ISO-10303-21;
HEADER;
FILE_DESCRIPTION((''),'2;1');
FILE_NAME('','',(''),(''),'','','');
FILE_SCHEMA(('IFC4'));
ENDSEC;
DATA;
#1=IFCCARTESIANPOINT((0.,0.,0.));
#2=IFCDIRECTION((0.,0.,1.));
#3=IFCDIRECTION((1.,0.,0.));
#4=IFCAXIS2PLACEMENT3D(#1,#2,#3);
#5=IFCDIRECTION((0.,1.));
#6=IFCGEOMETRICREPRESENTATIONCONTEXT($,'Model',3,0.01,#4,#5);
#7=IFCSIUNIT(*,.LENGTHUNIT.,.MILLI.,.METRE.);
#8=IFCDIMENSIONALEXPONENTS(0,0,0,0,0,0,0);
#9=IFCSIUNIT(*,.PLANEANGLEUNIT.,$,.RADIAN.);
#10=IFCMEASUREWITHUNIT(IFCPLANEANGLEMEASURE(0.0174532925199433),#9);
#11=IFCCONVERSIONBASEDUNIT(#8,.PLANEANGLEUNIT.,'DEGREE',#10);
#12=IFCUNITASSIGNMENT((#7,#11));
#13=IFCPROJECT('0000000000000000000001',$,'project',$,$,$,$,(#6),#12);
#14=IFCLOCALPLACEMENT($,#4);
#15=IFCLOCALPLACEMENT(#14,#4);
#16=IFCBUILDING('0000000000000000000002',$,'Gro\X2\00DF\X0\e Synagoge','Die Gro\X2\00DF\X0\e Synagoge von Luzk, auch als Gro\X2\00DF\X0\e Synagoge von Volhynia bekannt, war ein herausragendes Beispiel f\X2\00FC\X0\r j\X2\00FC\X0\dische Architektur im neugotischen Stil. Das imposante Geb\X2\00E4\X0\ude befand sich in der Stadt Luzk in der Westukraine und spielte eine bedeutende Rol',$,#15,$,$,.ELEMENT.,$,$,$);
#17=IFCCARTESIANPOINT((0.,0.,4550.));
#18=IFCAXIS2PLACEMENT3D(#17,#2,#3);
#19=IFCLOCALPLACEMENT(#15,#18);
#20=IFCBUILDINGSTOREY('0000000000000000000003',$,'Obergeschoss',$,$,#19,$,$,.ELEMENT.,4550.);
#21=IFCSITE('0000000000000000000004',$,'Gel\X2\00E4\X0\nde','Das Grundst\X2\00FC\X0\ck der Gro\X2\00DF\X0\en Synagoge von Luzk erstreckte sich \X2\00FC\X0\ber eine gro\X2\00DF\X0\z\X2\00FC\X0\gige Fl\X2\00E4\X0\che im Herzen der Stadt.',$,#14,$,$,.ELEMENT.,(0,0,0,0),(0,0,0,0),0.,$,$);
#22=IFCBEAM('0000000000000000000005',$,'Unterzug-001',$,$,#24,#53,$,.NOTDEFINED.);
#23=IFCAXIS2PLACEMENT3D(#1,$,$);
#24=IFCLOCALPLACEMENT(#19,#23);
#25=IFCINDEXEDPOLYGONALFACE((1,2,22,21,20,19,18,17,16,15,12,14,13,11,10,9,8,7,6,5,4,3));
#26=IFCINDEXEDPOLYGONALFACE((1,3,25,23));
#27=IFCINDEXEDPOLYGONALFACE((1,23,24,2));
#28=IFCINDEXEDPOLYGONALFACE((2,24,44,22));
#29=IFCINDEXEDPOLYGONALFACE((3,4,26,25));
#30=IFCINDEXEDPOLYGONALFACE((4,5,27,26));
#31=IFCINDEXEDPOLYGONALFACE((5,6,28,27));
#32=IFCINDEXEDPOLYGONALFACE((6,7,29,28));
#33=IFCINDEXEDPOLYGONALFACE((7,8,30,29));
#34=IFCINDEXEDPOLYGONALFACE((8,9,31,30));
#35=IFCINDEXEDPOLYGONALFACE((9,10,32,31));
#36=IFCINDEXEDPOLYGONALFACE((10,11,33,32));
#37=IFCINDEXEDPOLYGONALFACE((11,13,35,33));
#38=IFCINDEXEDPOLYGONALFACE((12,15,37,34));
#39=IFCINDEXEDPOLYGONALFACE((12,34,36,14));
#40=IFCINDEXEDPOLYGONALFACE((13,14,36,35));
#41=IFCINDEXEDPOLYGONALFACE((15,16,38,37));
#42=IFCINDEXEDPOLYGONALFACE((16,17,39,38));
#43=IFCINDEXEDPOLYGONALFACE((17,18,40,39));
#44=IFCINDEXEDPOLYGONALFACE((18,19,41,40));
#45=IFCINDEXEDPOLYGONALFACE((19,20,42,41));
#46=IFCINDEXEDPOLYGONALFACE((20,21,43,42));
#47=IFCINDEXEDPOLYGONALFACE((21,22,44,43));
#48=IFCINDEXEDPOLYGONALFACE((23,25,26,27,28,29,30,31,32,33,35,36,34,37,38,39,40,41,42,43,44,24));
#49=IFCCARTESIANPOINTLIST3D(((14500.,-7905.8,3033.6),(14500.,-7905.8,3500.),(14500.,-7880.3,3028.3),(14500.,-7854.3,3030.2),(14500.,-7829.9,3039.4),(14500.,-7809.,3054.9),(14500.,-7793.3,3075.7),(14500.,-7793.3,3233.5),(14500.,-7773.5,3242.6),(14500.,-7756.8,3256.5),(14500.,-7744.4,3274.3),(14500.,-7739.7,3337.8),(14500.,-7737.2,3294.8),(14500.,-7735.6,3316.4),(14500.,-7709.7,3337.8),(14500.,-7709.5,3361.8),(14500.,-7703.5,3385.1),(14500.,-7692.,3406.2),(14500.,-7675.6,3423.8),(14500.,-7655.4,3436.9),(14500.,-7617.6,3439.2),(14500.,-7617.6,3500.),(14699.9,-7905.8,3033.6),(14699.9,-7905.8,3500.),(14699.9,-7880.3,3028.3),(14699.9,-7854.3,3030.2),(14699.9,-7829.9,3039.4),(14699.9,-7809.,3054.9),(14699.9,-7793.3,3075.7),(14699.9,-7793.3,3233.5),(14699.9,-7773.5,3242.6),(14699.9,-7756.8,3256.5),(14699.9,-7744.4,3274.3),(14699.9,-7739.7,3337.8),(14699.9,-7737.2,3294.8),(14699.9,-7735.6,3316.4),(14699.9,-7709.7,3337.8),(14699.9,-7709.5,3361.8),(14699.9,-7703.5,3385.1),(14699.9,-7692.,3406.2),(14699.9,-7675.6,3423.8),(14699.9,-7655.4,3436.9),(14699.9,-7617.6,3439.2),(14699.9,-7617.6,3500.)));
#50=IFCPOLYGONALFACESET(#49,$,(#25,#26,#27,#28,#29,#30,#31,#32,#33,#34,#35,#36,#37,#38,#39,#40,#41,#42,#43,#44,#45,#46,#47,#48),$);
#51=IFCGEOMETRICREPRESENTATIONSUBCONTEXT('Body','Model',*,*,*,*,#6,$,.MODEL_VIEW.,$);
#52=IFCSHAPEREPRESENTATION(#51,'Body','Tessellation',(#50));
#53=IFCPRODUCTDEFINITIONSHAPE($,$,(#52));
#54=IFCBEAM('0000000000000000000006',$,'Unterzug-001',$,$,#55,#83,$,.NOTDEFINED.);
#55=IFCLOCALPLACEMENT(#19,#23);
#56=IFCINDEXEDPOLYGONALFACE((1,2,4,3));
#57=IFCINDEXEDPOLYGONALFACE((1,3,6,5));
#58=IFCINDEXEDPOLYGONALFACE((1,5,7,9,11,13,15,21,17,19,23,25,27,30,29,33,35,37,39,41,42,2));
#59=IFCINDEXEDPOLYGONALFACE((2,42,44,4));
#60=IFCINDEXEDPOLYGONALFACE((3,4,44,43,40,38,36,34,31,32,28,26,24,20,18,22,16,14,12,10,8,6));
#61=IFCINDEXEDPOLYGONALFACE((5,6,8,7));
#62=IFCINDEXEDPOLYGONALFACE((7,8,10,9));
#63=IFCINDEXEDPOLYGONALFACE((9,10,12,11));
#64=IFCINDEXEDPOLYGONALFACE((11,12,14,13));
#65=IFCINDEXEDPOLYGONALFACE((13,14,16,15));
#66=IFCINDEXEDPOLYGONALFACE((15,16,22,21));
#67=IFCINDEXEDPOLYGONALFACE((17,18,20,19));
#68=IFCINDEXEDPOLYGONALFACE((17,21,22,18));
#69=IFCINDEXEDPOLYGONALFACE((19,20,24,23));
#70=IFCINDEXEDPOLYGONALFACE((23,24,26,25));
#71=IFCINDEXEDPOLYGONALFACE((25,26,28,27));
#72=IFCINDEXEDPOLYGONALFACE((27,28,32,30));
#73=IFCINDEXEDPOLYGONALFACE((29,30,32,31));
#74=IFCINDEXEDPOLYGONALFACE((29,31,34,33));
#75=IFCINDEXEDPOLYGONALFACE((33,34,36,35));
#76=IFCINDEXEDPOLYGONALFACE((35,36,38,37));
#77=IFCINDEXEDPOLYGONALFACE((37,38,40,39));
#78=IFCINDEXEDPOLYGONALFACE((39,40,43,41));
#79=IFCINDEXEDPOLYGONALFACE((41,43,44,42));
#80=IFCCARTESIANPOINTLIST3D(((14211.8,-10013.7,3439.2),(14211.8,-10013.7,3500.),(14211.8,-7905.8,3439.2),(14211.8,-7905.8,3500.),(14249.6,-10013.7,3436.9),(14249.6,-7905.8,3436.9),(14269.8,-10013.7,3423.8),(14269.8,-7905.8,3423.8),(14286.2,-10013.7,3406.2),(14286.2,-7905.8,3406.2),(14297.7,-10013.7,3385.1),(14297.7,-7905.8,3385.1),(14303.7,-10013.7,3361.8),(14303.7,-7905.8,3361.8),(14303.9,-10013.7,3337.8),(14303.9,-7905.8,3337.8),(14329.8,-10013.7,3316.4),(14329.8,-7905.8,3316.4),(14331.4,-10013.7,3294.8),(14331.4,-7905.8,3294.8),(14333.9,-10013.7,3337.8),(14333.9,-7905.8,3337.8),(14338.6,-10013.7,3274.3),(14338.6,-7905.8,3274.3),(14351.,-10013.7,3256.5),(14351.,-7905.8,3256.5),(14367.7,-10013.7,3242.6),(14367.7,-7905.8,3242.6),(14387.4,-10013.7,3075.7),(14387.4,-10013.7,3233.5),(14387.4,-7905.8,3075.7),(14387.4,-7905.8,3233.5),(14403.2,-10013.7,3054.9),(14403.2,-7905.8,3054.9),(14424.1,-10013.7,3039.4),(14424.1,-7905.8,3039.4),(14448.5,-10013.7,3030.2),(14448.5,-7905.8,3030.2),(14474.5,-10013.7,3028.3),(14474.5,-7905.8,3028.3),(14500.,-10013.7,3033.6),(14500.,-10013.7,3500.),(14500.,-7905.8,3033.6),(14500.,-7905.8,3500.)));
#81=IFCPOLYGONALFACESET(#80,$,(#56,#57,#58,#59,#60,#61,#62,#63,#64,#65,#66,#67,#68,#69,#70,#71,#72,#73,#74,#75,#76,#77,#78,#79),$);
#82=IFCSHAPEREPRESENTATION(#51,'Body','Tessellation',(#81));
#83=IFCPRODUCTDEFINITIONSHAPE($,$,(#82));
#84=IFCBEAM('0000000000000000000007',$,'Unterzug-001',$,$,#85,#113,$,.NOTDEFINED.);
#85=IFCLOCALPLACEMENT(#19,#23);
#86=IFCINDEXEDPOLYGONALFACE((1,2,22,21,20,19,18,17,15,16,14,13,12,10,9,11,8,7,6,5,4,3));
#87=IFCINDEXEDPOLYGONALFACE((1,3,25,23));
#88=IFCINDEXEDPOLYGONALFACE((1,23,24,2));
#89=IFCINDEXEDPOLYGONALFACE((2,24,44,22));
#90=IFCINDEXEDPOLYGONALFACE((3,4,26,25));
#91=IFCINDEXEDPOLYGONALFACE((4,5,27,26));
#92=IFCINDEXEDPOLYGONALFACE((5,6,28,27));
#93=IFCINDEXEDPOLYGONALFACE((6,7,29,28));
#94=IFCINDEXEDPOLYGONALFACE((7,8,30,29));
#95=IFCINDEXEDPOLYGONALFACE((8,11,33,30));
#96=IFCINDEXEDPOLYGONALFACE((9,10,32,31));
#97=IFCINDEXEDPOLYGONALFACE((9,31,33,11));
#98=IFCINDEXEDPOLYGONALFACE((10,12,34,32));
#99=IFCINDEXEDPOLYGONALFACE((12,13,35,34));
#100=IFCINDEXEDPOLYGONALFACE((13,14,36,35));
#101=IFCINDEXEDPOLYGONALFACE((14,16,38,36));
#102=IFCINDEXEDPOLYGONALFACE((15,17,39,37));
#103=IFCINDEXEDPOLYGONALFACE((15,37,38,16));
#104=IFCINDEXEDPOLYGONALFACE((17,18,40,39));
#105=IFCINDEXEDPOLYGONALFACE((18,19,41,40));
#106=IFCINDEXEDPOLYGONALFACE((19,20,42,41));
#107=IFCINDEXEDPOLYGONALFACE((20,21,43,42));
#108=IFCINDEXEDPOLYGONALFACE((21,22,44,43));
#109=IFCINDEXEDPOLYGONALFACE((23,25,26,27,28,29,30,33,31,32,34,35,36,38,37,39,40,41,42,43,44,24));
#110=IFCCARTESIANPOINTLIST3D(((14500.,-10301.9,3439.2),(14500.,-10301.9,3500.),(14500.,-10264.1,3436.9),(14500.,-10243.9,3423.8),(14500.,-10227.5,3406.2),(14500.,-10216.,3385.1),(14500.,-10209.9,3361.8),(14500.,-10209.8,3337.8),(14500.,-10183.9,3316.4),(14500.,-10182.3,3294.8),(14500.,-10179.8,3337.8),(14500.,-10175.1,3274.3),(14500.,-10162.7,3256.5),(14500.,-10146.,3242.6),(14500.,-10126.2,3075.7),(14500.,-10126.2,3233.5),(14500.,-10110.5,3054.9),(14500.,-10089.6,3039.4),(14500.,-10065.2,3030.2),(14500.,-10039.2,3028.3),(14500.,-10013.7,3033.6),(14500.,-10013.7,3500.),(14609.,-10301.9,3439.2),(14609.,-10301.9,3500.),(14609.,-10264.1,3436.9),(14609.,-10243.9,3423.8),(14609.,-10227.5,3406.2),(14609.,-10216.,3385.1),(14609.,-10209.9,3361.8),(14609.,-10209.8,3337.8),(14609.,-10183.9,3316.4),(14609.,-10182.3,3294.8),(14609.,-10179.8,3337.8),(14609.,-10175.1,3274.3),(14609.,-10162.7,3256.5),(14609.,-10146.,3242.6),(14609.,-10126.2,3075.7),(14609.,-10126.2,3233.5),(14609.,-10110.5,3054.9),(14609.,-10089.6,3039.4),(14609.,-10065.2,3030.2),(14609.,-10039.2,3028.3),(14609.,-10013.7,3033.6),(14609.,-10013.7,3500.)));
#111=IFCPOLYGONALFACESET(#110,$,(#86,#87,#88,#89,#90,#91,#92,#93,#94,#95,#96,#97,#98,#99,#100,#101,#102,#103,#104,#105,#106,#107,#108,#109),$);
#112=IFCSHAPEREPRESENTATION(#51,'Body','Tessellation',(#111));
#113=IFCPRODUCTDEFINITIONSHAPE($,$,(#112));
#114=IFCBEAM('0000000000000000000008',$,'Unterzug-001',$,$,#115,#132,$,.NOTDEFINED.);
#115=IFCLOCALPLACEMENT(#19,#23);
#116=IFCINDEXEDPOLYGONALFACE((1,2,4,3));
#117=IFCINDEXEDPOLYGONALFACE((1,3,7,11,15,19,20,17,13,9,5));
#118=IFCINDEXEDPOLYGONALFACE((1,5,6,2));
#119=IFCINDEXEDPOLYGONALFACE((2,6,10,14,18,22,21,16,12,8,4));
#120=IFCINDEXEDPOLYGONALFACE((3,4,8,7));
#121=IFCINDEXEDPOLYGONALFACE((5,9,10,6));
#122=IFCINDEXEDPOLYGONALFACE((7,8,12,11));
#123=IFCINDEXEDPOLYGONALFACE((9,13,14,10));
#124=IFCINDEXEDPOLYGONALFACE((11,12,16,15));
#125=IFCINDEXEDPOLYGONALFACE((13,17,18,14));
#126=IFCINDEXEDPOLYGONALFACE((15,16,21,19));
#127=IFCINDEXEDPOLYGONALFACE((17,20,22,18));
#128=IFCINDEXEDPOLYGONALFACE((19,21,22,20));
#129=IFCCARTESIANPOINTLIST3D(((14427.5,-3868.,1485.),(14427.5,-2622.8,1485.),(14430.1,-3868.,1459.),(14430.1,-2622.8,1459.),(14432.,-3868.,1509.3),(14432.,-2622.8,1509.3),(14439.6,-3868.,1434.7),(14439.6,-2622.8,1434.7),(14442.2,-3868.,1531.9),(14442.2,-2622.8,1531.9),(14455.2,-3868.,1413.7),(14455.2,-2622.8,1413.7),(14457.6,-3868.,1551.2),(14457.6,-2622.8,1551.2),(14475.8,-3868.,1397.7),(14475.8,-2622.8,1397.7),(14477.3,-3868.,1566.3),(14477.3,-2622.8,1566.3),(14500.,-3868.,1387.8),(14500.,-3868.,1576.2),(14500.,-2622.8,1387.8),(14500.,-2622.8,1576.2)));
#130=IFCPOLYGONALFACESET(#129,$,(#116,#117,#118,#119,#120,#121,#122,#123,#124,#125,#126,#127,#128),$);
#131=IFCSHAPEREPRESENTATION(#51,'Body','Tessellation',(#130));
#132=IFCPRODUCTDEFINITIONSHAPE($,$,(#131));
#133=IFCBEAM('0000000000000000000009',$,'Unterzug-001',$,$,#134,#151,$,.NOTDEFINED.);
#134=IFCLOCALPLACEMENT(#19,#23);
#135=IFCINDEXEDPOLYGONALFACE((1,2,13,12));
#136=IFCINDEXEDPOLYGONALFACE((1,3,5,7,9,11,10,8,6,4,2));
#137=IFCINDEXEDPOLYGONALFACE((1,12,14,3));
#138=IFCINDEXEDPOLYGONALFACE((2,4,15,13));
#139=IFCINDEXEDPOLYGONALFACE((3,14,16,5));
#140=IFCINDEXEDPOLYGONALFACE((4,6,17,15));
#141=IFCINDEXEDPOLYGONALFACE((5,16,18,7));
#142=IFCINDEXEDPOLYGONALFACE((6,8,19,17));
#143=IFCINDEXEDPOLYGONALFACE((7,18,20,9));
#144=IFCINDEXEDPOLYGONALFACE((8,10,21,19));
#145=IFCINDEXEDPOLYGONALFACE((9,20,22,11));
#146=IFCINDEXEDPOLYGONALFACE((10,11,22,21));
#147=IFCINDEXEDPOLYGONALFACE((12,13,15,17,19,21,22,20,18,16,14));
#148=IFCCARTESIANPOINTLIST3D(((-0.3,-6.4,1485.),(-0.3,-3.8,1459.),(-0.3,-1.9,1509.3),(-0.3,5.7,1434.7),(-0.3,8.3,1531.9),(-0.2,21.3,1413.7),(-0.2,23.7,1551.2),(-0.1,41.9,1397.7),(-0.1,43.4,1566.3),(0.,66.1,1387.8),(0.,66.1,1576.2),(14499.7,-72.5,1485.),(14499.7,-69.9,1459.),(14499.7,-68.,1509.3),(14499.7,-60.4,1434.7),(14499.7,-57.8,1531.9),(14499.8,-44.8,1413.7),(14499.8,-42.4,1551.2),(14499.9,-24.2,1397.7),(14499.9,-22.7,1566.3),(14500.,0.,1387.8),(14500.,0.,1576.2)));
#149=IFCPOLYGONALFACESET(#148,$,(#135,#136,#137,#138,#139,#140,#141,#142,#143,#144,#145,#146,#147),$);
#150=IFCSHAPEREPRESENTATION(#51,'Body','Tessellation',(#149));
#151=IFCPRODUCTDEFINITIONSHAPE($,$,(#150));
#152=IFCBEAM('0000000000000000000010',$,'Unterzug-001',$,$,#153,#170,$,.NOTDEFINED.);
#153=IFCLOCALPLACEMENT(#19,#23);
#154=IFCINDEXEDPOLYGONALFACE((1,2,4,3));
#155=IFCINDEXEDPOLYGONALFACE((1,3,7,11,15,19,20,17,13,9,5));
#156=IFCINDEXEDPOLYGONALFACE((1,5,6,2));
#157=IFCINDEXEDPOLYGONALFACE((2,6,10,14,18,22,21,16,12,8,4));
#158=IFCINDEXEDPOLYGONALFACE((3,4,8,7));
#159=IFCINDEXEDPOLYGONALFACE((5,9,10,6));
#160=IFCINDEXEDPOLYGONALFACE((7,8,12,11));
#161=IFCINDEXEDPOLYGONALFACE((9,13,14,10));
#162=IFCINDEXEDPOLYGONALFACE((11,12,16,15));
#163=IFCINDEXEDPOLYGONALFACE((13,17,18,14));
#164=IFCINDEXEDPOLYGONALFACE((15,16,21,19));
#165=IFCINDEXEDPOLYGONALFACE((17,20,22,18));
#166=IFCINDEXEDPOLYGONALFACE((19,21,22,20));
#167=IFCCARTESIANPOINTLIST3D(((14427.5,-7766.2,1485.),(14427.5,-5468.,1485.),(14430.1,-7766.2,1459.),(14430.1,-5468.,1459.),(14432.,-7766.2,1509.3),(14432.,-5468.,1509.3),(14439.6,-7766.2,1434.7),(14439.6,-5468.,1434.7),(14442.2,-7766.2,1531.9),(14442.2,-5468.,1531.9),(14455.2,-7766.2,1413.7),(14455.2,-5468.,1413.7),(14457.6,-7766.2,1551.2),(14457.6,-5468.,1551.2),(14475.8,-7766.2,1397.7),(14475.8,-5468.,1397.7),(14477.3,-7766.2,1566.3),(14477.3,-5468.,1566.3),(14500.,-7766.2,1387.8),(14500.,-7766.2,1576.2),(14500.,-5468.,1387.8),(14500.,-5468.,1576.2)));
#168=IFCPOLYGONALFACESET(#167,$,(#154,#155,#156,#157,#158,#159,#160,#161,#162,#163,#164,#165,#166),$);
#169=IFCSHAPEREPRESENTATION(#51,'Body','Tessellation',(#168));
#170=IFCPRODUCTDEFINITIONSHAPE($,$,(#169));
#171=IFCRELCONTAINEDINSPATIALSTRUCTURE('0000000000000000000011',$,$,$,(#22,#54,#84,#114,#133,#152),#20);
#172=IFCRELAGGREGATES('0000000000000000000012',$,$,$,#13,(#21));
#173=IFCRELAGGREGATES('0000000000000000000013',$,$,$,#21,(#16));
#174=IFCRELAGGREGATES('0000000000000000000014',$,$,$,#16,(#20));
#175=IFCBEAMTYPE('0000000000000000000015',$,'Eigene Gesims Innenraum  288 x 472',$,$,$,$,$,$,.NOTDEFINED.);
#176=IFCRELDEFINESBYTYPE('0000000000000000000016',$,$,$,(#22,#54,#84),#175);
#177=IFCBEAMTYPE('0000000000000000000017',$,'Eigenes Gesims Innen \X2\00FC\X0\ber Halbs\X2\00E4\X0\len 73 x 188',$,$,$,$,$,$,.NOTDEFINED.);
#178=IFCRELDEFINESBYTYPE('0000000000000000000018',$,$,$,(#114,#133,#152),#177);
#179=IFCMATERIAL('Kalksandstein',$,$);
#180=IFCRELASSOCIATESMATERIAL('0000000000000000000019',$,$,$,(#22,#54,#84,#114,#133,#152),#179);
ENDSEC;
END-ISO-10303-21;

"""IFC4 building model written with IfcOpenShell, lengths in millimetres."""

from ifc_helpers import new_model, entity, si_unit, converted_unit, direction, frame, origin_with_axes, place, context, subcontext, project, spatial, line, arc, indexed_curve, outline, extrude, material, material_profile, profile_set, type_object, element, save


model = new_model("IFC4")

# Units and contexts
model_context = context("Model", 3, precision=0.01, world=origin_with_axes(), true_north=direction((0.0, 1.0)))
body_context = subcontext(model_context, "Body", "Model", "MODEL_VIEW")
ifc_project = project(units=[si_unit("LENGTHUNIT", "METRE", prefix="MILLI"), converted_unit("PLANEANGLEUNIT", "DEGREE", entity("IfcPlaneAngleMeasure", 0.0174532925199433), si_unit("PLANEANGLEUNIT", "RADIAN"), dimensions=[0, 0, 0, 0, 0, 0, 0])], contexts=[model_context])

# Site, building, storey
site_placement = place(None, origin_with_axes())
site = spatial("IfcSite", under=ifc_project, at=site_placement, Name="Gelände", Description="Das Grundstück der Großen Synagoge von Luzk erstreckte sich über eine großzügige Fläche im Herzen der Stadt.", CompositionType="ELEMENT", RefLatitude=(0, 0, 0, 0), RefLongitude=(0, 0, 0, 0), RefElevation=0.0)
building_placement = place(site_placement, origin_with_axes())
building = spatial("IfcBuilding", under=site, at=building_placement, Name="Große Synagoge", Description="Die Große Synagoge von Luzk, auch als Große Synagoge von Volhynia bekannt, war ein herausragendes Beispiel für jüdische Architektur im neugotischen Stil. Das imposante Gebäude befand sich in der Stadt Luzk in der Westukraine und spielte eine bedeutende Rol", CompositionType="ELEMENT")
storey_placement = place(building_placement, frame((0.0, 0.0, 4550.0), z_axis=(0.0, 0.0, 1.0), x_axis=(1.0, 0.0, 0.0)))
storey = spatial("IfcBuildingStorey", under=building, at=storey_placement, Name="Obergeschoss", CompositionType="ELEMENT", Elevation=4550.0)

# Beams
ifc_material_1 = material(Name="Kalksandstein")
ifc_material_profile_1 = material_profile(ifc_material_1, outline(indexed_curve([(0.0, 0.0), (0.0, -466.4), (64.0, -466.1), (112.6, -424.3), (112.6, -266.5), (161.4, -225.7), (166.1, -162.2), (196.1, -162.2), (207.4, -104.0), (250.4, -63.1), (288.2, -60.8), (288.2, 0.0)], segments=[line(1, 2), arc(2, 3, 4), line(4, 5), arc(5, 6, 7), line(7, 8), arc(8, 9, 10), line(10, 11, 12, 1)])), Name="Kalksandstein")
ifc_profile_set_1 = profile_set([ifc_material_profile_1], Name="Eigene Gesims Innenraum ")
beam_type_1 = type_object("IfcBeamType", Name="Eigene Gesims Innenraum  288 x 472", PredefinedType="NOTDEFINED")
beam_1_placement = place(storey_placement, frame((14699.9, -7905.8, 3500.0), z_axis=(0.0, 0.0, 1.0), x_axis=(0.0, 1.0, 0.0)))
element("IfcBeam", 1, at=beam_1_placement, inside=storey, type_object=beam_type_1, material=ifc_profile_set_1, Name="Unterzug-001", PredefinedType="NOTDEFINED", context=body_context, shape_type="SweptSolid", body=[
    extrude(outline(indexed_curve([(0.0, 0.0), (0.0, -466.4), (64.0, -466.1), (112.6, -424.3), (112.6, -266.5), (161.4, -225.7), (166.1, -162.2), (196.1, -162.2), (207.4, -104.0), (250.4, -63.1), (288.2, -60.8), (288.2, 0.0)], segments=[line(1, 2), arc(2, 3, 4), line(4, 5), arc(5, 6, 7), line(7, 8), arc(8, 9, 10), line(10, 11, 12, 1)])), frame((0.0, 199.9, 0.0), z_axis=(0.0, -1.0, 0.0), x_axis=(1.0, 0.0, 0.0)), (0.0, 0.0, 1.0), 199.9),
])
beam_2_placement = place(storey_placement, frame((14500.0, -7905.8, 3500.0), z_axis=(0.0, 0.0, 1.0), x_axis=(-1.0, 0.0, 0.0)))
element("IfcBeam", 2, at=beam_2_placement, inside=storey, type_object=beam_type_1, material=ifc_profile_set_1, Name="Unterzug-001", PredefinedType="NOTDEFINED", context=body_context, shape_type="SweptSolid", body=[
    extrude(outline(indexed_curve([(0.0, 0.0), (0.0, -466.4), (64.0, -466.1), (112.6, -424.3), (112.6, -266.5), (161.4, -225.7), (166.1, -162.2), (196.1, -162.2), (207.4, -104.0), (250.4, -63.1), (288.2, -60.8), (288.2, 0.0)], segments=[line(1, 2), arc(2, 3, 4), line(4, 5), arc(5, 6, 7), line(7, 8), arc(8, 9, 10), line(10, 11, 12, 1)])), frame((0.0, 2107.9, 0.0), z_axis=(0.0, -1.0, 0.0), x_axis=(1.0, 0.0, 0.0)), (0.0, 0.0, 1.0), 2107.9),
])
beam_3_placement = place(storey_placement, frame((14500.0, -10013.7, 3500.0), z_axis=(0.0, 0.0, 1.0), x_axis=(0.0, -1.0, 0.0)))
element("IfcBeam", 3, at=beam_3_placement, inside=storey, type_object=beam_type_1, material=ifc_profile_set_1, Name="Unterzug-001", PredefinedType="NOTDEFINED", context=body_context, shape_type="SweptSolid", body=[
    extrude(outline(indexed_curve([(0.0, 0.0), (0.0, -466.4), (64.0, -466.1), (112.6, -424.3), (112.6, -266.5), (161.4, -225.7), (166.1, -162.2), (196.1, -162.2), (207.4, -104.0), (250.4, -63.1), (288.2, -60.8), (288.2, 0.0)], segments=[line(1, 2), arc(2, 3, 4), line(4, 5), arc(5, 6, 7), line(7, 8), arc(8, 9, 10), line(10, 11, 12, 1)])), frame((0.0, 109.0, 0.0), z_axis=(0.0, -1.0, 0.0), x_axis=(1.0, 0.0, 0.0)), (0.0, 0.0, 1.0), 109.0),
])
ifc_material_profile_2 = material_profile(ifc_material_1, outline(indexed_curve([(72.5, -91.2), (50.7, -34.1), (0.0, 0.0), (0.0, -188.3), (53.3, -152.5)], segments=[arc(1, 2, 3), line(3, 4), arc(4, 5, 1)])), Name="Kalksandstein")
ifc_profile_set_2 = profile_set([ifc_material_profile_2], Name="Eigenes Gesims Innen über Halbsälen")
beam_type_2 = type_object("IfcBeamType", Name="Eigenes Gesims Innen über Halbsälen 73 x 188", PredefinedType="NOTDEFINED")
beam_4_placement = place(storey_placement, frame((14500.0, -3868.0, 1576.2), z_axis=(0.0, 0.0, 1.0), x_axis=(1.0, 0.0, 0.0)))
element("IfcBeam", 4, at=beam_4_placement, inside=storey, type_object=beam_type_2, material=ifc_profile_set_2, Name="Unterzug-001", PredefinedType="NOTDEFINED", context=body_context, shape_type="SweptSolid", body=[
    extrude(outline(indexed_curve([(72.5, -91.2), (50.7, -34.1), (0.0, 0.0), (0.0, -188.3), (53.3, -152.5)], segments=[arc(1, 2, 3), line(3, 4), arc(4, 5, 1)])), frame((0.0, 1245.2, 0.0), z_axis=(0.0, 1.0, 0.0), x_axis=(-1.0, 0.0, 0.0)), (0.0, 0.0, -1.0), 1245.2),
])
beam_5_placement = place(storey_placement, frame((14500.0, 0.0, 1576.2), z_axis=(0.0, 0.0, 1.0), x_axis=(0.004557, 0.99999, 0.0)))
element("IfcBeam", 5, at=beam_5_placement, inside=storey, type_object=beam_type_2, material=ifc_profile_set_2, Name="Unterzug-001", PredefinedType="NOTDEFINED", context=body_context, shape_type="SweptSolid", body=[
    extrude(outline(indexed_curve([(72.5, -91.2), (50.7, -34.1), (0.0, 0.0), (0.0, -188.3), (53.3, -152.5)], segments=[arc(1, 2, 3), line(3, 4), arc(4, 5, 1)])), frame((0.0, 14500.2, 0.0), z_axis=(0.0, 1.0, 0.0), x_axis=(-1.0, 0.0, 0.0)), (0.0, 0.0, -1.0), 14500.2),
])
beam_6_placement = place(storey_placement, frame((14500.0, -7766.2, 1576.2), z_axis=(0.0, 0.0, 1.0), x_axis=(1.0, 0.0, 0.0)))
element("IfcBeam", 6, at=beam_6_placement, inside=storey, type_object=beam_type_2, material=ifc_profile_set_2, Name="Unterzug-001", PredefinedType="NOTDEFINED", context=body_context, shape_type="SweptSolid", body=[
    extrude(outline(indexed_curve([(72.5, -91.2), (50.7, -34.1), (0.0, 0.0), (0.0, -188.3), (53.3, -152.5)], segments=[arc(1, 2, 3), line(3, 4), arc(4, 5, 1)])), frame((0.0, 2298.1, 0.0), z_axis=(0.0, 1.0, 0.0), x_axis=(-1.0, 0.0, 0.0)), (0.0, 0.0, -1.0), 2298.1),
])

save(model, "model.ifc")
